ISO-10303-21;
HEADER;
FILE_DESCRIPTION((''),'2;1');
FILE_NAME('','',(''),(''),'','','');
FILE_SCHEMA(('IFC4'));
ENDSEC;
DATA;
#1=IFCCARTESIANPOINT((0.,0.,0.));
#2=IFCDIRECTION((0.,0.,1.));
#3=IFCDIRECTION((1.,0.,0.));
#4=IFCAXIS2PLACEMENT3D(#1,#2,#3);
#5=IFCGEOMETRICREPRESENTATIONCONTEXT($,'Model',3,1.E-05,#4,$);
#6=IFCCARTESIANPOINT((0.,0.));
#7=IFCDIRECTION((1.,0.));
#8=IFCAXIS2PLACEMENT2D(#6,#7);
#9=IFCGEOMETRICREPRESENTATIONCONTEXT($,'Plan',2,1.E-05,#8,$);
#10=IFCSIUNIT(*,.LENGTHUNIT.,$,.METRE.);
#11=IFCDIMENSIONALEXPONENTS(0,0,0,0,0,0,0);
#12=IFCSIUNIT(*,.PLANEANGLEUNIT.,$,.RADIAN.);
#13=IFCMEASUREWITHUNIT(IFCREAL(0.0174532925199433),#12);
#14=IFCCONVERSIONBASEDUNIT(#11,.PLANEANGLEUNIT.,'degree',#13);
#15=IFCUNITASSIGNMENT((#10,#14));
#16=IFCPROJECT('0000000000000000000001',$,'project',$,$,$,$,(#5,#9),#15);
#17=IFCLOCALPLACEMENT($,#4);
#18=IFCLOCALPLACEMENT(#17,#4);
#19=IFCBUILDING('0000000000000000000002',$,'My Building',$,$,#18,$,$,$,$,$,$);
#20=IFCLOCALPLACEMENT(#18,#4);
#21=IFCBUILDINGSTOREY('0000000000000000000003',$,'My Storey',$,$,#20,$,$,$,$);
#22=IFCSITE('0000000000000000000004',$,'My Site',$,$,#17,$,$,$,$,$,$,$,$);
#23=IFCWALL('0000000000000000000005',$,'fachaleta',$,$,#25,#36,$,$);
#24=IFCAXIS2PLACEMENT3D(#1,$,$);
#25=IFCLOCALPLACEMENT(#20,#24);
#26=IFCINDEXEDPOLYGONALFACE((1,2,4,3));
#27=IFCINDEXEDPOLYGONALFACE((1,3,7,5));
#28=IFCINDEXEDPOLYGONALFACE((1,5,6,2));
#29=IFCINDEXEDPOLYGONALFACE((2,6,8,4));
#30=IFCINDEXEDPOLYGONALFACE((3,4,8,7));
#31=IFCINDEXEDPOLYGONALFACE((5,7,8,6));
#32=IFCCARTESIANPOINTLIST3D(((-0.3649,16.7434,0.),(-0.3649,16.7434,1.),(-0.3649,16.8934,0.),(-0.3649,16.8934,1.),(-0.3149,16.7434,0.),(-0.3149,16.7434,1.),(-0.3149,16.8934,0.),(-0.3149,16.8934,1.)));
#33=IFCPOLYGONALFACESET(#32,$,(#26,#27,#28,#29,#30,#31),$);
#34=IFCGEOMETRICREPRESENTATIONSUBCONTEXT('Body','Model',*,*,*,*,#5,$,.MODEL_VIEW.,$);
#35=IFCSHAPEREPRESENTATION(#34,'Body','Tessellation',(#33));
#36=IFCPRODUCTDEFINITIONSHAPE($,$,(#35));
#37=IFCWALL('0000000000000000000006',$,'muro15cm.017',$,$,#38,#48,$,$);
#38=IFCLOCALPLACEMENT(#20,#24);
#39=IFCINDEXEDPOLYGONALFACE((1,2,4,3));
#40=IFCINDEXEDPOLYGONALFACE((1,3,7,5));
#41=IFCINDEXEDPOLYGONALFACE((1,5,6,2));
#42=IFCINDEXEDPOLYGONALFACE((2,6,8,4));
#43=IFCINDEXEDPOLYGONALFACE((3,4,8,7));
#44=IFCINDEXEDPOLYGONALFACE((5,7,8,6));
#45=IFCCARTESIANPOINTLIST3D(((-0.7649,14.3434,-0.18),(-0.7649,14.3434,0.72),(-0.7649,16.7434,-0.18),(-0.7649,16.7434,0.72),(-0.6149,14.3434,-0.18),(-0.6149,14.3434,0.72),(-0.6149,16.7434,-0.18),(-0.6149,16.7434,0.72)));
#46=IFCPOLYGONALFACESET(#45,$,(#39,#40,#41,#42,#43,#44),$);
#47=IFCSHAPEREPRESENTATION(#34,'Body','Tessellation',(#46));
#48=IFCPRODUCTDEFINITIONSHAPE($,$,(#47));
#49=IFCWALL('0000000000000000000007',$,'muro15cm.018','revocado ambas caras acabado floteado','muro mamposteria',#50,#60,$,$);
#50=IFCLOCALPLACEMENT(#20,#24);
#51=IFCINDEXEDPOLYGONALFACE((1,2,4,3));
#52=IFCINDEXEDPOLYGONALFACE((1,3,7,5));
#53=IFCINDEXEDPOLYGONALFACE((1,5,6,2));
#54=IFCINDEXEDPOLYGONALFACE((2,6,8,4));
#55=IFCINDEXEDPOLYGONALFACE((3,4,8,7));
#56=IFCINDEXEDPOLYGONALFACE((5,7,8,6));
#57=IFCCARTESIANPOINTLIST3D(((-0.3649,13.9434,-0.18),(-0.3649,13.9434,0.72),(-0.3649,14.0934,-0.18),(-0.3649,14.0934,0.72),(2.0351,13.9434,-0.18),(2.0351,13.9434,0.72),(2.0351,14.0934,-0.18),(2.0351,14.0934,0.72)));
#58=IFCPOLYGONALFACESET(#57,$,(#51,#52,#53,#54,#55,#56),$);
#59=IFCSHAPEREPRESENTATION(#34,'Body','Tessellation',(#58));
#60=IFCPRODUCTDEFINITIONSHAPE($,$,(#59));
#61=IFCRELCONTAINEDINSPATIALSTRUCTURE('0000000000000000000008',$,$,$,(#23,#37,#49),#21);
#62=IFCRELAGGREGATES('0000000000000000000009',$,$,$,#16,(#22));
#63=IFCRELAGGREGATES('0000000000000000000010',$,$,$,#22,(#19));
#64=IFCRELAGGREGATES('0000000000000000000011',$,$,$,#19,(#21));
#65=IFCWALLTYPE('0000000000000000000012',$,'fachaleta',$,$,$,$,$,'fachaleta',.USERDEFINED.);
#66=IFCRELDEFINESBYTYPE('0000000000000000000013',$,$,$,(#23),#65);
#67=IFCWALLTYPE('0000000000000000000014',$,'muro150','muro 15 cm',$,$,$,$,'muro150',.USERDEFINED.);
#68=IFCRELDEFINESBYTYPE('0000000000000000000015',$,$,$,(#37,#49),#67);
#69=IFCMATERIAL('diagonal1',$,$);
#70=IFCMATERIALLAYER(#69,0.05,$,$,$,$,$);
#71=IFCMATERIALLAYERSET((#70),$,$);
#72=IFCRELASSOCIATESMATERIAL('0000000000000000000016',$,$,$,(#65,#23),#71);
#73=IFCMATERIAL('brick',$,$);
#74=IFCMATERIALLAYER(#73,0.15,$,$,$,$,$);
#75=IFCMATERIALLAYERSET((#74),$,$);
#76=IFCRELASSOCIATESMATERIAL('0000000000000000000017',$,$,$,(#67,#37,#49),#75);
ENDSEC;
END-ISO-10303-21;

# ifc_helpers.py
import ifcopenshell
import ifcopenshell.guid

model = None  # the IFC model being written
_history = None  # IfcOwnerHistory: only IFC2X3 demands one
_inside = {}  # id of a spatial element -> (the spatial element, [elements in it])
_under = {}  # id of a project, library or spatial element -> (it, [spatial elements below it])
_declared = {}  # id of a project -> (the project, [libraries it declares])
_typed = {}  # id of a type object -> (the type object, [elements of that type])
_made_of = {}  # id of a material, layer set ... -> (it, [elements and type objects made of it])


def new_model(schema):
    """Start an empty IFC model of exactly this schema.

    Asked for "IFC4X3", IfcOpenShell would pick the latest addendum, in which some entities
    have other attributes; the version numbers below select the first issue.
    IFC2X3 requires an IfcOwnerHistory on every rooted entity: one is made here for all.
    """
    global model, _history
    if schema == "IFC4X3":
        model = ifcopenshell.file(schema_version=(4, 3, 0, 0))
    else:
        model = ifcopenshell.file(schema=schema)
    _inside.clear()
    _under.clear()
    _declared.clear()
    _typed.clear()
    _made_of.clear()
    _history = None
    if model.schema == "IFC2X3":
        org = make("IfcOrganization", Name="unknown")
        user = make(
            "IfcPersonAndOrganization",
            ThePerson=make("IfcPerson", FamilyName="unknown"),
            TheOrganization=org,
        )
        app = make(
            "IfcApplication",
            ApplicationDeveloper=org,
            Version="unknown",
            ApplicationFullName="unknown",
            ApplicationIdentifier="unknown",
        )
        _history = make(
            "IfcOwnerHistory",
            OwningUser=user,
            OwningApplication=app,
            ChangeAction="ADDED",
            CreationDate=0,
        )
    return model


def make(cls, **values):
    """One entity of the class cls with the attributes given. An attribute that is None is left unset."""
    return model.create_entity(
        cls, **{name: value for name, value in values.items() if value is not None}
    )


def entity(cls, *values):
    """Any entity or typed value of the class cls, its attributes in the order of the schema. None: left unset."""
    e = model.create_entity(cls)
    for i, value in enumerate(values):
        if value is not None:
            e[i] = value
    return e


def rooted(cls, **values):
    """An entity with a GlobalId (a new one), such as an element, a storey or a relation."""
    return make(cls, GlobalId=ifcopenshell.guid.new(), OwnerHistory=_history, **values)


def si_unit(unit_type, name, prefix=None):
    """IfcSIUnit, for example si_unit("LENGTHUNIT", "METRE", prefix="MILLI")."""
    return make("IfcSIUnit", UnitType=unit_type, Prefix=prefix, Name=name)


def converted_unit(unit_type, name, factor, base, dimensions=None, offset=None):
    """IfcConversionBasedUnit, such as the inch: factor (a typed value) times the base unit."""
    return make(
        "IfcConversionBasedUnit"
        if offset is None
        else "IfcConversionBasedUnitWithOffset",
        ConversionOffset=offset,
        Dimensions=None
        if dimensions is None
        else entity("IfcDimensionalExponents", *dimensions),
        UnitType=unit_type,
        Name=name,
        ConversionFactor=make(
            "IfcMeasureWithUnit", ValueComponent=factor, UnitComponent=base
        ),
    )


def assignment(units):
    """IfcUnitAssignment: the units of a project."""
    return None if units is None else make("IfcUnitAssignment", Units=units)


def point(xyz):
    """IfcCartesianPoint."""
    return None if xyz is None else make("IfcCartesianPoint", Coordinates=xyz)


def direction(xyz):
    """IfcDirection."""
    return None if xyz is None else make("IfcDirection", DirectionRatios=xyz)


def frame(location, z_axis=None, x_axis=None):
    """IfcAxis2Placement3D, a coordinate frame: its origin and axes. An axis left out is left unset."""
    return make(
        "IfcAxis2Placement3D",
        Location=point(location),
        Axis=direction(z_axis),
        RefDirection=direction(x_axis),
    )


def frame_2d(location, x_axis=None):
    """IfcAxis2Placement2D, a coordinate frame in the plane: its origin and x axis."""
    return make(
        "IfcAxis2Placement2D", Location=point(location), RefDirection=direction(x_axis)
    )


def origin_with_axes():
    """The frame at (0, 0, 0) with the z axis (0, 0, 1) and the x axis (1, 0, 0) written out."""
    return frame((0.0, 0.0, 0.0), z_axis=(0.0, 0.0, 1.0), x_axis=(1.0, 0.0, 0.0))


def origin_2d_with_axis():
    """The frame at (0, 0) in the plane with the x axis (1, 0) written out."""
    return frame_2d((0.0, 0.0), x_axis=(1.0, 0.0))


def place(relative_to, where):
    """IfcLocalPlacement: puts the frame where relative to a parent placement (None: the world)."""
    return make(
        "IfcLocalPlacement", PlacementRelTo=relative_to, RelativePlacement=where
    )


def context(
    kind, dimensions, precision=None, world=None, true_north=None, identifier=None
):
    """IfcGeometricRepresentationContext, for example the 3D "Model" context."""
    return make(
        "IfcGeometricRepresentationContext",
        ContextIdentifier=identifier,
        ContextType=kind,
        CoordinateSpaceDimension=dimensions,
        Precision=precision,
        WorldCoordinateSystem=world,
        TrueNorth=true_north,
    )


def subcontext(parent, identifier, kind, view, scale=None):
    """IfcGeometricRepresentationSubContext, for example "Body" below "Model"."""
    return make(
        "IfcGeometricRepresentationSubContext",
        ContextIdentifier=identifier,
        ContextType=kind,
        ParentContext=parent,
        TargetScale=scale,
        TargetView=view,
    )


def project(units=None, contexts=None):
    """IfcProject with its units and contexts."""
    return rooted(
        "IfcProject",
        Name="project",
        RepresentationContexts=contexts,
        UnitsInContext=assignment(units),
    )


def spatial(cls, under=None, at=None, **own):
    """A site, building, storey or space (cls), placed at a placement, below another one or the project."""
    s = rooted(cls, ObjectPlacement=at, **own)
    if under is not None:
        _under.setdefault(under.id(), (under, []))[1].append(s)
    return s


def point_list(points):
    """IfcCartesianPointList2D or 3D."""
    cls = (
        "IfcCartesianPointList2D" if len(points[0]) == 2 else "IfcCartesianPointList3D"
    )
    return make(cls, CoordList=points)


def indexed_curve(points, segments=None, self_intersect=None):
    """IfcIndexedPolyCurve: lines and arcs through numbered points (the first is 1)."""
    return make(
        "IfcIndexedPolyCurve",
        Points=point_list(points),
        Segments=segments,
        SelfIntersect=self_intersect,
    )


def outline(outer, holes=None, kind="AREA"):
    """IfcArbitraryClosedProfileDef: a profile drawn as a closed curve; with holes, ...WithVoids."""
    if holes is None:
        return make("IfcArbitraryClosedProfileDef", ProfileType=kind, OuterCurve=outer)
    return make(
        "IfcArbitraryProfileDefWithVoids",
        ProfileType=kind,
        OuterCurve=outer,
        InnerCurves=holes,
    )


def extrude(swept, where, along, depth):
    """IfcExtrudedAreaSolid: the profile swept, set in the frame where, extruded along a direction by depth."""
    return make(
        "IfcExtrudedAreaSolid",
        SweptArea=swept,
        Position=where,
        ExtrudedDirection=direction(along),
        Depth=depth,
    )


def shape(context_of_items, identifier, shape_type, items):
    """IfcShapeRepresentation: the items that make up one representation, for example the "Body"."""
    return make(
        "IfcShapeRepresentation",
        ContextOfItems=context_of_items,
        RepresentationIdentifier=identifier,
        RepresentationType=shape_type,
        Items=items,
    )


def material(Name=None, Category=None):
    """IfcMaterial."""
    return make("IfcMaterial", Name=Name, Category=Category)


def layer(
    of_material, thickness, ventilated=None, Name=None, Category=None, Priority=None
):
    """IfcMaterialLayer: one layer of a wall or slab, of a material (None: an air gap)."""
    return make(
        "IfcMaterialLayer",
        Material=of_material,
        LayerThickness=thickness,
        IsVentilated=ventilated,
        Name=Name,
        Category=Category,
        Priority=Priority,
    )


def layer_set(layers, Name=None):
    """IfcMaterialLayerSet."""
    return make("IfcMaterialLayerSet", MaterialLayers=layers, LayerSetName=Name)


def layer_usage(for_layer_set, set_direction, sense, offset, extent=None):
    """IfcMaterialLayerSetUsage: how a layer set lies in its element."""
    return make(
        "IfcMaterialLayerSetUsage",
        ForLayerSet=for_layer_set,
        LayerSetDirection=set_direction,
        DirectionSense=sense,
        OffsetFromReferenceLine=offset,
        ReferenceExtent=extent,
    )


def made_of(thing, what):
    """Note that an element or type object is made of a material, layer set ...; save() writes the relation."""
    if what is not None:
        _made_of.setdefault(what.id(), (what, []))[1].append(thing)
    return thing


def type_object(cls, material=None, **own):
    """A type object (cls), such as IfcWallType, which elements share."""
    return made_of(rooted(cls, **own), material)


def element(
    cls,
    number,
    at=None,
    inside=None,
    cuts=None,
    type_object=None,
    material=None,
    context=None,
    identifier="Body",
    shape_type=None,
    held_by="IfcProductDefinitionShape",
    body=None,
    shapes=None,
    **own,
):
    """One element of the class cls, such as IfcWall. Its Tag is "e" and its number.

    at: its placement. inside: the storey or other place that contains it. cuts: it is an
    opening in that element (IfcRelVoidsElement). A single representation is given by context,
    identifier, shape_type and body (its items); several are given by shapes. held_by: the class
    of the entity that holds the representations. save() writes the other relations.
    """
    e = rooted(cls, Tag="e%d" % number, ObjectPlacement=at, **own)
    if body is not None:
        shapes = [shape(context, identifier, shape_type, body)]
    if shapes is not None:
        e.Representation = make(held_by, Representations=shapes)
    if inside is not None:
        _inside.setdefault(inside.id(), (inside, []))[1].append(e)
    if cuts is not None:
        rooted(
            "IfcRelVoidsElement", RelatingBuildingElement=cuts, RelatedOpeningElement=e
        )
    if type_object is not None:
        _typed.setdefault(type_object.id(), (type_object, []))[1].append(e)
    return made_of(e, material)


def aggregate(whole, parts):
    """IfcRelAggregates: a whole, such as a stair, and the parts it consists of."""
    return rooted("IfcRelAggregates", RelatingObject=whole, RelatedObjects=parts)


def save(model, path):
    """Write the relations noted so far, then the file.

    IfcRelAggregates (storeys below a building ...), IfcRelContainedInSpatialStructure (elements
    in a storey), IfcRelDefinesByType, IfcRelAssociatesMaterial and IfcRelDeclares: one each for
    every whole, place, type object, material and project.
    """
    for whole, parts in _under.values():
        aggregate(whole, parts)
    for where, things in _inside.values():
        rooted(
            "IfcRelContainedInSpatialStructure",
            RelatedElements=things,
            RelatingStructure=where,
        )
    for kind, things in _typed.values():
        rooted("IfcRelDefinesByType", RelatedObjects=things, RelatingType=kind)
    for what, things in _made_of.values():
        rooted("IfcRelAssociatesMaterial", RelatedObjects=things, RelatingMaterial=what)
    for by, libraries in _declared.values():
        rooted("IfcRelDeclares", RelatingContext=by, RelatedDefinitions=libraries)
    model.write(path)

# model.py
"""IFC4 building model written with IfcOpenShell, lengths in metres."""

from ifc_helpers import new_model, entity, si_unit, converted_unit, frame, origin_with_axes, origin_2d_with_axis, place, context, subcontext, project, spatial, indexed_curve, outline, extrude, material, layer, layer_set, layer_usage, type_object, element, save


model = new_model("IFC4")

# Units and contexts
model_context = context("Model", 3, precision=1e-05, world=origin_with_axes())
plan_context = context("Plan", 2, precision=1e-05, world=origin_2d_with_axis())
body_context = subcontext(model_context, "Body", "Model", "MODEL_VIEW")
ifc_project = project(units=[si_unit("LENGTHUNIT", "METRE"), converted_unit("PLANEANGLEUNIT", "degree", entity("IfcReal", 0.0174532925199433), si_unit("PLANEANGLEUNIT", "RADIAN"), dimensions=[0, 0, 0, 0, 0, 0, 0])], contexts=[model_context, plan_context])

# Site, building, storey
site_placement = place(None, origin_with_axes())
site = spatial("IfcSite", under=ifc_project, at=site_placement, Name="My Site")
building_placement = place(site_placement, origin_with_axes())
building = spatial("IfcBuilding", under=site, at=building_placement, Name="My Building")
storey_placement = place(building_placement, origin_with_axes())
storey = spatial("IfcBuildingStorey", under=building, at=storey_placement, Name="My Storey")

# Walls
ifc_material_1 = material(Name="diagonal1")
ifc_layer_1 = layer(ifc_material_1, 0.05)
ifc_layer_set_1 = layer_set([ifc_layer_1])
wall_type_1 = type_object("IfcWallType", Name="fachaleta", ElementType="fachaleta", PredefinedType="USERDEFINED", material=ifc_layer_set_1)
ifc_layer_usage_1 = layer_usage(ifc_layer_set_1, "AXIS2", "POSITIVE", 0.0)
wall_1_placement = place(storey_placement, frame((-0.3149, 16.7434, 0.0), z_axis=(0.0, 0.0, 1.0), x_axis=(0.0, 1.0, 0.0)))
element("IfcWall", 1, at=wall_1_placement, inside=storey, type_object=wall_type_1, material=ifc_layer_usage_1, Name="fachaleta", context=body_context, shape_type="SweptSolid", body=[
    extrude(outline(indexed_curve([(0.0, 0.0), (0.0, 0.05), (0.15, 0.05), (0.15, 0.0), (0.0, 0.0)], self_intersect=False)), origin_with_axes(), (0.0, 0.0, 1.0), 1.0),
])
ifc_material_2 = material(Name="brick")
ifc_layer_2 = layer(ifc_material_2, 0.15)
ifc_layer_set_2 = layer_set([ifc_layer_2])
ifc_layer_usage_2 = layer_usage(ifc_layer_set_2, "AXIS2", "POSITIVE", 0.0)
wall_type_2 = type_object("IfcWallType", Name="muro150", Description="muro 15 cm", ElementType="muro150", PredefinedType="USERDEFINED", material=ifc_layer_set_2)
wall_2_placement = place(storey_placement, frame((-0.7649, 16.7434, -0.18), z_axis=(0.0, 0.0, 1.0), x_axis=(0.0, -1.0, 0.0)))
element("IfcWall", 2, at=wall_2_placement, inside=storey, type_object=wall_type_2, material=ifc_layer_usage_2, Name="muro15cm.017", context=body_context, shape_type="SweptSolid", body=[
    extrude(outline(indexed_curve([(0.0, 0.0), (0.0, 0.15), (2.4, 0.15), (2.4, 0.0), (0.0, 0.0)], self_intersect=False)), origin_with_axes(), (0.0, 0.0, 1.0), 0.9),
])
ifc_layer_usage_3 = layer_usage(ifc_layer_set_2, "AXIS2", "POSITIVE", 0.0)
wall_3_placement = place(storey_placement, frame((-0.3649, 13.9434, -0.18), z_axis=(0.0, 0.0, 1.0), x_axis=(1.0, 0.0, 0.0)))
element("IfcWall", 3, at=wall_3_placement, inside=storey, type_object=wall_type_2, material=ifc_layer_usage_3, Name="muro15cm.018", Description="revocado ambas caras acabado floteado", ObjectType="muro mamposteria", context=body_context, shape_type="SweptSolid", body=[
    extrude(outline(indexed_curve([(0.0, 0.0), (0.0, 0.15), (2.4, 0.15), (2.4, 0.0), (0.0, 0.0)], self_intersect=False)), origin_with_axes(), (0.0, 0.0, 1.0), 0.9),
])

save(model, "model.ifc")
